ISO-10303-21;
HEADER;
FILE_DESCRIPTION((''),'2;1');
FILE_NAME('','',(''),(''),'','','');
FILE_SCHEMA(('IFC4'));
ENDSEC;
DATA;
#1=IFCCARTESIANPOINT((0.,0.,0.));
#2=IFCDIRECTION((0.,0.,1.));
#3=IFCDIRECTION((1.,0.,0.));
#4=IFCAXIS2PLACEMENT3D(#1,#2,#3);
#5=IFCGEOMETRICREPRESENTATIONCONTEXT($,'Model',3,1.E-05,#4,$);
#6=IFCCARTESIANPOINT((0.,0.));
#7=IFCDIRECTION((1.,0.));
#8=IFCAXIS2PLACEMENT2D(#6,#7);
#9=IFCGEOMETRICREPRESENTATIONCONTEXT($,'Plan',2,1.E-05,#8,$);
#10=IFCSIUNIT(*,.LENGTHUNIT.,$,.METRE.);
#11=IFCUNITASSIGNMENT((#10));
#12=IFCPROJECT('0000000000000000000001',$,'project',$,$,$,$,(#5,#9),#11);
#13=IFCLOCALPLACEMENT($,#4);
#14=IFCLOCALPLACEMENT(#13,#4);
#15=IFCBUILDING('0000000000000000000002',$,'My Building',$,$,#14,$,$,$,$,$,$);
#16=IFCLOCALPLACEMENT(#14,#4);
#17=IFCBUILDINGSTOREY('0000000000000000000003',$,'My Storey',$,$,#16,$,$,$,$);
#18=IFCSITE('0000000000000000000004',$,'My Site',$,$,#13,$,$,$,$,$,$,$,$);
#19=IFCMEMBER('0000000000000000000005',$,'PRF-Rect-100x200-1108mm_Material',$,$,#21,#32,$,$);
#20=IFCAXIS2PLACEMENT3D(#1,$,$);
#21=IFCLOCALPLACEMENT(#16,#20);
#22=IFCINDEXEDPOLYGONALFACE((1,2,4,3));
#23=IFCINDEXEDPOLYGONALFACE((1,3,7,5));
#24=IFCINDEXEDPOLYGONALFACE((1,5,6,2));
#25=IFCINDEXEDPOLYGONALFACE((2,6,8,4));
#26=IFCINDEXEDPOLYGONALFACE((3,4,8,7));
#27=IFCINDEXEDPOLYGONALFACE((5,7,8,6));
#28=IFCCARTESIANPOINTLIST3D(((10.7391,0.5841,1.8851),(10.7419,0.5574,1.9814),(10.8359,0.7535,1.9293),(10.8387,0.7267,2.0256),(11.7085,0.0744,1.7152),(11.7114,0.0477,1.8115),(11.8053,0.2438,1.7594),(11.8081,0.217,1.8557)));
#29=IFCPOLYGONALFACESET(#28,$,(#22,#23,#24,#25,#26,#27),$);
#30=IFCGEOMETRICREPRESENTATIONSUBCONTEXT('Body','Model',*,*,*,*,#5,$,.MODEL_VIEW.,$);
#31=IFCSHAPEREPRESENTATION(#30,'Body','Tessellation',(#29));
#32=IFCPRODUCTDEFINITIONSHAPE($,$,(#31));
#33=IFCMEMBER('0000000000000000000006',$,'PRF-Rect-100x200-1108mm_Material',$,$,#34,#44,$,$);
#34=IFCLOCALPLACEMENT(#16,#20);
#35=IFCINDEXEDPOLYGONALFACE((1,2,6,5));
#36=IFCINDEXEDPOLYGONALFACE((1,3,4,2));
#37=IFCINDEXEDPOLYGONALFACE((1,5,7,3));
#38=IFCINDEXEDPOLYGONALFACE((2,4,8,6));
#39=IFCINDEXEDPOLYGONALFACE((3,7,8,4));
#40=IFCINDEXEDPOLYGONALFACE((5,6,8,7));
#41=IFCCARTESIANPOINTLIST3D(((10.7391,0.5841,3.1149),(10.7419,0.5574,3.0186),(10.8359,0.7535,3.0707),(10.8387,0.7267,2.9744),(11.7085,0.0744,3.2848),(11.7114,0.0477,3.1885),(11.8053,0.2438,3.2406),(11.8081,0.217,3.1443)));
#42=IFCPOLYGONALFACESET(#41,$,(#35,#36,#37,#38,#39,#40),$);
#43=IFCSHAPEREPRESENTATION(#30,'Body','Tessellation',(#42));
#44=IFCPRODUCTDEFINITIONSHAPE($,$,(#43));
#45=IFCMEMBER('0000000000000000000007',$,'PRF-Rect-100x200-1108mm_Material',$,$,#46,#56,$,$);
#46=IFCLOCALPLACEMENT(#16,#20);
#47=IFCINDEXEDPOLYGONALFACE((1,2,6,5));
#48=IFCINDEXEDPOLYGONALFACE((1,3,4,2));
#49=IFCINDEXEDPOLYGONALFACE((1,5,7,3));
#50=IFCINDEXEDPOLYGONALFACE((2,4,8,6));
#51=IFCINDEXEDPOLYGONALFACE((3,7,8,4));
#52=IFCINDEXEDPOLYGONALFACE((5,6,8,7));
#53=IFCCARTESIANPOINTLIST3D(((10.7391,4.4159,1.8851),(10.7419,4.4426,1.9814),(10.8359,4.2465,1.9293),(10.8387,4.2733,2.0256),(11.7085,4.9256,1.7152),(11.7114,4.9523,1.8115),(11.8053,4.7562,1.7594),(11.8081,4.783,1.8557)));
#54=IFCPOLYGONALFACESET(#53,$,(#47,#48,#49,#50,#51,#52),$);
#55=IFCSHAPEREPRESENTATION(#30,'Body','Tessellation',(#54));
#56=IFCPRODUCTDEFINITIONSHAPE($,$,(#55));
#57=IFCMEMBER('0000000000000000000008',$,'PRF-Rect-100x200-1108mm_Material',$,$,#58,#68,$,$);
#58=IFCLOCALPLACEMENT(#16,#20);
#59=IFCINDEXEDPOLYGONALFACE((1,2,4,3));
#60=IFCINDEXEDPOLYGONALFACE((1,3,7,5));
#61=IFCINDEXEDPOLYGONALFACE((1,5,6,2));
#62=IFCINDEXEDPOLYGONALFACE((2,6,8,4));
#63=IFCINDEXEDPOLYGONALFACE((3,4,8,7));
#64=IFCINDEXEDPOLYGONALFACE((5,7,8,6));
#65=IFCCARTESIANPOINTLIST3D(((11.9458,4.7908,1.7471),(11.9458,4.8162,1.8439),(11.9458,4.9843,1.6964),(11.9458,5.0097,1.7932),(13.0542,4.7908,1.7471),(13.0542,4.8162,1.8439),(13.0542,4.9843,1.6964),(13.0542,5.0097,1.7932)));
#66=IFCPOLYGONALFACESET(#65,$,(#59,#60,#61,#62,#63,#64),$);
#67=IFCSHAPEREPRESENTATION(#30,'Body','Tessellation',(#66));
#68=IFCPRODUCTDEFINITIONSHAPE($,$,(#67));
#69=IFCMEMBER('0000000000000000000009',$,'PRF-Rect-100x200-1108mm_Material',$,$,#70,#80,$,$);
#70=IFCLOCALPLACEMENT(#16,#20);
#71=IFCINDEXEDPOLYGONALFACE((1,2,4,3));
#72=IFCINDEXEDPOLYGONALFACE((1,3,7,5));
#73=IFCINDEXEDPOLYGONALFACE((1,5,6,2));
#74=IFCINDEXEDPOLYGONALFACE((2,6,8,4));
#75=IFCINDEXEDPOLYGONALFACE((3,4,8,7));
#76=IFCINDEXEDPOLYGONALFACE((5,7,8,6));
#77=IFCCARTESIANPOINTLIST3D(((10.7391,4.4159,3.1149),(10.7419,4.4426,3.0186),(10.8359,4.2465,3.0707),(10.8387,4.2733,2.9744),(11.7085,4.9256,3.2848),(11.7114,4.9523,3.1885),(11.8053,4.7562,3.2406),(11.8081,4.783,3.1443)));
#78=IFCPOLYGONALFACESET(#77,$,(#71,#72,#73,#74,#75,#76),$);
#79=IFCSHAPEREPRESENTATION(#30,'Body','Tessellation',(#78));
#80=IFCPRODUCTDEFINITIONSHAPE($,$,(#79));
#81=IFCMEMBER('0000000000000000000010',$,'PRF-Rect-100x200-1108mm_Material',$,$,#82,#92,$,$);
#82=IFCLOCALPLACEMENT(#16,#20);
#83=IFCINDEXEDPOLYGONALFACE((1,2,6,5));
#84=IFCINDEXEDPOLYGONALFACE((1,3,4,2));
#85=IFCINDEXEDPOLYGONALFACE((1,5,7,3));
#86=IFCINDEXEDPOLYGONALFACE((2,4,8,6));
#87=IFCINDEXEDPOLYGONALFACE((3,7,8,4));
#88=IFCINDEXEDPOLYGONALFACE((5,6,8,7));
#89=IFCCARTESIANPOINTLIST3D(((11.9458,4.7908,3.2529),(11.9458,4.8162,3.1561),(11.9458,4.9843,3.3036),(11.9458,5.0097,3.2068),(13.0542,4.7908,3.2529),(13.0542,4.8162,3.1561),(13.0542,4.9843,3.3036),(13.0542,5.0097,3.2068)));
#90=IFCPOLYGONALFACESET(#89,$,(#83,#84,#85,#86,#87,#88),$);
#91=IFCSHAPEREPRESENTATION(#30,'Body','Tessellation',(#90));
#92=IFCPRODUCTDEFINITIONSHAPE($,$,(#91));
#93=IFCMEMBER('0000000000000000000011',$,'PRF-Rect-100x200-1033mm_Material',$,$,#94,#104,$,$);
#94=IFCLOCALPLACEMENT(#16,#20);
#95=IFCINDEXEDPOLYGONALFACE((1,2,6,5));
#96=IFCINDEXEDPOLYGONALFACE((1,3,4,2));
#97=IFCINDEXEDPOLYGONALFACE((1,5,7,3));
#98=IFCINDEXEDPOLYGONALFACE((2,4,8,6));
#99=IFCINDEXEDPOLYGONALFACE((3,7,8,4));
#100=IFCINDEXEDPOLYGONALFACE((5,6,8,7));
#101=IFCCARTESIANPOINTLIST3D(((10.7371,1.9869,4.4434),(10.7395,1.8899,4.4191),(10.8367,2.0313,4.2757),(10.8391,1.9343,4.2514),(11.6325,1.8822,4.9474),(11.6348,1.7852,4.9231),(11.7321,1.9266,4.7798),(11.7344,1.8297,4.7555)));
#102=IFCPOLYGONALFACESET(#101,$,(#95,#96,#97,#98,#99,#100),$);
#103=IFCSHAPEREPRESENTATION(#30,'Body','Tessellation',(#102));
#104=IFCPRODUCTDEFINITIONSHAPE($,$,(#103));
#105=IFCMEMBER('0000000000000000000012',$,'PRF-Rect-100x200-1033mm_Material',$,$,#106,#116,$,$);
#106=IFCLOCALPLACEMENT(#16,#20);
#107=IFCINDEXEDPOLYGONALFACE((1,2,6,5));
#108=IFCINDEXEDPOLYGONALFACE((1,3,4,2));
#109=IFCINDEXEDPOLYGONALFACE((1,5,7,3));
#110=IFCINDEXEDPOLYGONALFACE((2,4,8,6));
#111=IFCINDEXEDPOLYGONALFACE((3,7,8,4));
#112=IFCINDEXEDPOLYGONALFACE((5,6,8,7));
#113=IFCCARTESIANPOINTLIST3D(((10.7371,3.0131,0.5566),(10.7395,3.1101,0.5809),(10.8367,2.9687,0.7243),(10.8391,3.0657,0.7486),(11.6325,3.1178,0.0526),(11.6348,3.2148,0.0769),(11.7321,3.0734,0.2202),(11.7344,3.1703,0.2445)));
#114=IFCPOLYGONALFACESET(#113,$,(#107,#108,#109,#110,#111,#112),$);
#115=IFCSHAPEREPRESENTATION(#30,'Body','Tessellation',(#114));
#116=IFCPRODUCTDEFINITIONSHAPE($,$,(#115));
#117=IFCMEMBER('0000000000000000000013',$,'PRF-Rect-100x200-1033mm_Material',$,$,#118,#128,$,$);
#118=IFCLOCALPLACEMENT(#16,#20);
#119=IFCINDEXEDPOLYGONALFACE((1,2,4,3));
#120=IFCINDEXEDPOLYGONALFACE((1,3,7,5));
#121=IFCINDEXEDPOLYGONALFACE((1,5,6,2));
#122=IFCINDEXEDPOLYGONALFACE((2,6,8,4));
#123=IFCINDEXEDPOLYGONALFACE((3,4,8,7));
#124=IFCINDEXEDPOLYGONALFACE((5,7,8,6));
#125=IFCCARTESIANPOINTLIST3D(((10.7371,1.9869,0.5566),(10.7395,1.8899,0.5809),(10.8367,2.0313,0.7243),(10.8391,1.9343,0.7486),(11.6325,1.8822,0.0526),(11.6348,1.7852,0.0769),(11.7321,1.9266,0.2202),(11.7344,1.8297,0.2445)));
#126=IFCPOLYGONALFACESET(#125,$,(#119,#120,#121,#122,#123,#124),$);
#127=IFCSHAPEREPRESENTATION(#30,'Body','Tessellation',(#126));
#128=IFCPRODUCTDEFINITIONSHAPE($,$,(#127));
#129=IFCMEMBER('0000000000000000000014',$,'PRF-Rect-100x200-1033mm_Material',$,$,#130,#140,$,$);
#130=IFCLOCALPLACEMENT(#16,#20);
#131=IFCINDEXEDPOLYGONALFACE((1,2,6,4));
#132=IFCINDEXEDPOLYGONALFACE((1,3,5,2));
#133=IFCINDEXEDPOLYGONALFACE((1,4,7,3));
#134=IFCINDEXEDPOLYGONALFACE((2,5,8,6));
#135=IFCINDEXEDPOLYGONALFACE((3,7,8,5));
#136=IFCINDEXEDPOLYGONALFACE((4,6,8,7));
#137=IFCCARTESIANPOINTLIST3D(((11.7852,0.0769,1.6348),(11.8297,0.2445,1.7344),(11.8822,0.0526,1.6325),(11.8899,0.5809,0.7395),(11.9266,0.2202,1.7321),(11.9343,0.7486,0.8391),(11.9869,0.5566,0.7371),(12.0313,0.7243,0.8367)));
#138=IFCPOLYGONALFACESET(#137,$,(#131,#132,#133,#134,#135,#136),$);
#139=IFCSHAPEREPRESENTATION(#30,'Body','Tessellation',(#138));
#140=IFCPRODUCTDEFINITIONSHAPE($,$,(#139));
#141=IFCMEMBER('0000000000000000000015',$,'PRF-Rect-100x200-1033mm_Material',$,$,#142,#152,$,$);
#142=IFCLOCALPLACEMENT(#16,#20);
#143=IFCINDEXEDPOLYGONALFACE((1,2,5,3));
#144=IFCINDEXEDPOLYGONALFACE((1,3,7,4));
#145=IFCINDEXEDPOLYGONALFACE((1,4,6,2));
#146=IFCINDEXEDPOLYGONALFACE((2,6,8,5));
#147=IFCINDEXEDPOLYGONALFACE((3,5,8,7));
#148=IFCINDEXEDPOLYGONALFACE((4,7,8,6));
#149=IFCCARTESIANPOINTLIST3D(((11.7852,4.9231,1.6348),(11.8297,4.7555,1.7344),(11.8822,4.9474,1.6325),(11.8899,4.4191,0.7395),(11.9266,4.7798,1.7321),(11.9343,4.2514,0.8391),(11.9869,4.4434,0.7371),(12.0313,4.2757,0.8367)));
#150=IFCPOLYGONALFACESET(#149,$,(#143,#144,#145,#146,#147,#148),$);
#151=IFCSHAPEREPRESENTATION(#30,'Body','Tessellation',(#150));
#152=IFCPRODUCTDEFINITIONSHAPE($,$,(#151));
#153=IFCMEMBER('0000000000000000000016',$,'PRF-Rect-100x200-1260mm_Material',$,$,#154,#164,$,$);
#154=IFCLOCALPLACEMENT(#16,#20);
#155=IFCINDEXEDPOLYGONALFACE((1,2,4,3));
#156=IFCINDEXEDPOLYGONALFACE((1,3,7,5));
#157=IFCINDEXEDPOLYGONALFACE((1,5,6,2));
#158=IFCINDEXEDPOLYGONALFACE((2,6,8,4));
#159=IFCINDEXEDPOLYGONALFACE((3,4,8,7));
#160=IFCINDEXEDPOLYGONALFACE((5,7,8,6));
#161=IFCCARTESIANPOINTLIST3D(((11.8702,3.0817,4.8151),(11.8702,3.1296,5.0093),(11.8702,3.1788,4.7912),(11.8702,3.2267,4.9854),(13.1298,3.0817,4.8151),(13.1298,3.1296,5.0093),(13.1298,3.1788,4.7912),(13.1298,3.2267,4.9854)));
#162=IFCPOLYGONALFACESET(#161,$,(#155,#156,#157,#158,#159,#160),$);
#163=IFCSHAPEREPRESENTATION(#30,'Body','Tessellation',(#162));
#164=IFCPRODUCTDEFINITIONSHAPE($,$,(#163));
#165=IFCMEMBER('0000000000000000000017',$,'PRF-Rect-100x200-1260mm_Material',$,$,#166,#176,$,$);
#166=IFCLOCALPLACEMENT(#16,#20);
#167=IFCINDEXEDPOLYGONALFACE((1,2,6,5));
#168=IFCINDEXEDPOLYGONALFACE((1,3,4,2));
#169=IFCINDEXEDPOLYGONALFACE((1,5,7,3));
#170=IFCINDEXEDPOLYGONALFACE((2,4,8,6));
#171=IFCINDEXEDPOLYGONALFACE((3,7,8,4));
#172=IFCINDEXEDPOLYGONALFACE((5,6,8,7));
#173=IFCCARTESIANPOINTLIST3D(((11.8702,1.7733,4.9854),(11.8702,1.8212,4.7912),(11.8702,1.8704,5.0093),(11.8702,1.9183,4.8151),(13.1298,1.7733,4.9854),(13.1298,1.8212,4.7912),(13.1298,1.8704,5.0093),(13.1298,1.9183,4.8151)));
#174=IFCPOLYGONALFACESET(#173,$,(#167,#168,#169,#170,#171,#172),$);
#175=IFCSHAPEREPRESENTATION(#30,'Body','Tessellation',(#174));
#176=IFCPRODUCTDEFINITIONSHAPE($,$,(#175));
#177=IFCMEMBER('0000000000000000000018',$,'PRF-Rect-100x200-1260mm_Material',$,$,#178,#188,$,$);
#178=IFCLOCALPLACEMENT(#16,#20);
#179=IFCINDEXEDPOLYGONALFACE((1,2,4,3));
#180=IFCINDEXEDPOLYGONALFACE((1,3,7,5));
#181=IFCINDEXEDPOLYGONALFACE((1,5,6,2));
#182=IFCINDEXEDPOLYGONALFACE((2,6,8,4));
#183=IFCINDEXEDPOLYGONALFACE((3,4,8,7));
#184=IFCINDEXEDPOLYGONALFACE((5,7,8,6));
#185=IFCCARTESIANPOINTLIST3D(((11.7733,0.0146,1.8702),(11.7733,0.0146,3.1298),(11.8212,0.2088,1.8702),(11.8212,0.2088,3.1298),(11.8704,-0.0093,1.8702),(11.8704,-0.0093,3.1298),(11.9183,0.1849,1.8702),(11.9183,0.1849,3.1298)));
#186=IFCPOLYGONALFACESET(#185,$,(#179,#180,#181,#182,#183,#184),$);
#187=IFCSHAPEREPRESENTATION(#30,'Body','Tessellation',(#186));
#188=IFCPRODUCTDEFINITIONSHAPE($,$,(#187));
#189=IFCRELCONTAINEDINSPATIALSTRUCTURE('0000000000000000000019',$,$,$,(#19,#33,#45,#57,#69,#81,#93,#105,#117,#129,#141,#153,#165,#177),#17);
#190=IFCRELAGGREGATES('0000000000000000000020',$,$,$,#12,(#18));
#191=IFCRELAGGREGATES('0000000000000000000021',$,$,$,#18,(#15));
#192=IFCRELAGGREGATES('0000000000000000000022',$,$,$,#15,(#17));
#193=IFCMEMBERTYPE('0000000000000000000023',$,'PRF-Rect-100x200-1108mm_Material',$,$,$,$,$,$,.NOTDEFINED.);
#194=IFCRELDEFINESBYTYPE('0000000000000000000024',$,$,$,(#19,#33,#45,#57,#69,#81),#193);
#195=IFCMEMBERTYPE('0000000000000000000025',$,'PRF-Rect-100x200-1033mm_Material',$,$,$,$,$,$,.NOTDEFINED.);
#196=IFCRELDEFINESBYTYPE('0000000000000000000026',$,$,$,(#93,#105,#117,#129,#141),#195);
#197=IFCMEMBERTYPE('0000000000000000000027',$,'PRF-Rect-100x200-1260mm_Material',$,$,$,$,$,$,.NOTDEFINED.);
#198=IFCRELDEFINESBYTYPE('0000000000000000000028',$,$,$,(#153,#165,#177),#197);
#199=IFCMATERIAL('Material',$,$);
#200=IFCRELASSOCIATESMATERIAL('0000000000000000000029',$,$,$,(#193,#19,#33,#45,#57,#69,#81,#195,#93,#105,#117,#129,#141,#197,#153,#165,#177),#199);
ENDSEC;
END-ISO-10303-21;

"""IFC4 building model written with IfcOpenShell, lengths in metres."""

from ifc_helpers import new_model, si_unit, frame, origin, origin_with_axes, origin_2d_with_axis, place, context, subcontext, project, spatial, rectangle, extrude, material, material_profile, profile_set, profile_usage, type_object, element, save


model = new_model("IFC4")

# Units and contexts
model_context = context("Model", 3, precision=1e-05, world=origin_with_axes())
plan_context = context("Plan", 2, precision=1e-05, world=origin_2d_with_axis())
body_context = subcontext(model_context, "Body", "Model", "MODEL_VIEW")
ifc_project = project(units=[si_unit("LENGTHUNIT", "METRE")], contexts=[model_context, plan_context])

# Site, building, storey
site_placement = place(None, origin_with_axes())
site = spatial("IfcSite", under=ifc_project, at=site_placement, Name="My Site")
building_placement = place(site_placement, origin_with_axes())
building = spatial("IfcBuilding", under=site, at=building_placement, Name="My Building")
storey_placement = place(building_placement, origin_with_axes())
storey = spatial("IfcBuildingStorey", under=building, at=storey_placement, Name="My Storey")

# Members
ifc_material = material(Name="Material")
ifc_material_profile_1 = material_profile(ifc_material, rectangle(XDim=0.1, YDim=0.2))
ifc_profile_set_1 = profile_set([ifc_material_profile_1], Name="PRF-Rect-100x200-1108mm_Material")
member_type_1 = type_object("IfcMemberType", Name="PRF-Rect-100x200-1108mm_Material", PredefinedType="NOTDEFINED", material=ifc_profile_set_1)
ifc_profile_usage_1 = profile_usage(ifc_profile_set_1, cardinal=5)
member_1_placement = place(storey_placement, frame((11.7583, 0.1457, 1.7855), z_axis=(-0.874667, 0.459849, 0.153283), x_axis=(-0.028153, 0.2675, -0.963147)))
element("IfcMember", 1, at=member_1_placement, inside=storey, type_object=member_type_1, material=ifc_profile_usage_1, Name="PRF-Rect-100x200-1108mm_Material", context=body_context, shape_type="SweptSolid", body=[
    extrude(rectangle(XDim=0.1, YDim=0.2), origin(), (0.0, 0.0, 1.0), 1.1084),
])
ifc_profile_usage_2 = profile_usage(ifc_profile_set_1, cardinal=5)
member_2_placement = place(storey_placement, frame((11.7583, 0.1457, 3.2145), z_axis=(-0.874668, 0.459849, -0.153283), x_axis=(0.028153, -0.2675, -0.963147)))
element("IfcMember", 2, at=member_2_placement, inside=storey, type_object=member_type_1, material=ifc_profile_usage_2, Name="PRF-Rect-100x200-1108mm_Material", context=body_context, shape_type="SweptSolid", body=[
    extrude(rectangle(XDim=0.1, YDim=0.2), origin(), (0.0, 0.0, 1.0), 1.1084),
])
ifc_profile_usage_3 = profile_usage(ifc_profile_set_1, cardinal=5)
member_3_placement = place(storey_placement, frame((10.7889, 4.3446, 1.9554), z_axis=(0.874668, 0.459849, -0.153283), x_axis=(-0.028153, -0.2675, -0.963147)))
element("IfcMember", 3, at=member_3_placement, inside=storey, type_object=member_type_1, material=ifc_profile_usage_3, Name="PRF-Rect-100x200-1108mm_Material", context=body_context, shape_type="SweptSolid", body=[
    extrude(rectangle(XDim=0.1, YDim=0.2), origin(), (0.0, 0.0, 1.0), 1.1084),
])
ifc_profile_usage_4 = profile_usage(ifc_profile_set_1, cardinal=5)
member_4_placement = place(storey_placement, frame((11.9458, 4.9002, 1.7702), z_axis=(1.0, 0.0, 0.0), x_axis=(0.0, -0.253569, -0.967317)))
element("IfcMember", 4, at=member_4_placement, inside=storey, type_object=member_type_1, material=ifc_profile_usage_4, Name="PRF-Rect-100x200-1108mm_Material", context=body_context, shape_type="SweptSolid", body=[
    extrude(rectangle(XDim=0.1, YDim=0.2), origin(), (0.0, 0.0, 1.0), 1.1084),
])
ifc_profile_usage_5 = profile_usage(ifc_profile_set_1, cardinal=5)
member_5_placement = place(storey_placement, frame((10.7889, 4.3446, 3.0446), z_axis=(0.874667, 0.459849, 0.153283), x_axis=(0.028153, 0.2675, -0.963147)))
element("IfcMember", 5, at=member_5_placement, inside=storey, type_object=member_type_1, material=ifc_profile_usage_5, Name="PRF-Rect-100x200-1108mm_Material", context=body_context, shape_type="SweptSolid", body=[
    extrude(rectangle(XDim=0.1, YDim=0.2), origin(), (0.0, 0.0, 1.0), 1.1084),
])
ifc_profile_usage_6 = profile_usage(ifc_profile_set_1, cardinal=5)
member_6_placement = place(storey_placement, frame((11.9458, 4.9002, 3.2298), z_axis=(1.0, 0.0, 0.0), x_axis=(0.0, 0.253569, -0.967317)))
element("IfcMember", 6, at=member_6_placement, inside=storey, type_object=member_type_1, material=ifc_profile_usage_6, Name="PRF-Rect-100x200-1108mm_Material", context=body_context, shape_type="SweptSolid", body=[
    extrude(rectangle(XDim=0.1, YDim=0.2), origin(), (0.0, 0.0, 1.0), 1.1084),
])
ifc_material_profile_2 = material_profile(ifc_material, rectangle(XDim=0.1, YDim=0.2))
ifc_profile_set_2 = profile_set([ifc_material_profile_2], Name="PRF-Rect-100x200-1033mm_Material")
ifc_profile_usage_7 = profile_usage(ifc_profile_set_2, cardinal=5)
member_type_2 = type_object("IfcMemberType", Name="PRF-Rect-100x200-1033mm_Material", PredefinedType="NOTDEFINED", material=ifc_profile_set_2)
member_7_placement = place(storey_placement, frame((10.7881, 1.9606, 4.3474), z_axis=(0.866922, -0.101315, 0.488039), x_axis=(-0.023454, 0.969748, 0.242978)))
element("IfcMember", 7, at=member_7_placement, inside=storey, type_object=member_type_2, material=ifc_profile_usage_7, Name="PRF-Rect-100x200-1033mm_Material", context=body_context, shape_type="SweptSolid", body=[
    extrude(rectangle(XDim=0.1, YDim=0.2), origin(), (0.0, 0.0, 1.0), 1.0328),
])
ifc_profile_usage_8 = profile_usage(ifc_profile_set_2, cardinal=5)
member_8_placement = place(storey_placement, frame((11.6835, 3.1441, 0.1486), z_axis=(-0.866922, -0.101314, 0.488039), x_axis=(0.023454, 0.969748, 0.242978)))
element("IfcMember", 8, at=member_8_placement, inside=storey, type_object=member_type_2, material=ifc_profile_usage_8, Name="PRF-Rect-100x200-1033mm_Material", context=body_context, shape_type="SweptSolid", body=[
    extrude(rectangle(XDim=0.1, YDim=0.2), origin(), (0.0, 0.0, 1.0), 1.0328),
])
ifc_profile_usage_9 = profile_usage(ifc_profile_set_2, cardinal=5)
member_9_placement = place(storey_placement, frame((11.6835, 1.8559, 0.1486), z_axis=(-0.866922, 0.101314, 0.488039), x_axis=(-0.023455, 0.969748, -0.242978)))
element("IfcMember", 9, at=member_9_placement, inside=storey, type_object=member_type_2, material=ifc_profile_usage_9, Name="PRF-Rect-100x200-1033mm_Material", context=body_context, shape_type="SweptSolid", body=[
    extrude(rectangle(XDim=0.1, YDim=0.2), origin(), (0.0, 0.0, 1.0), 1.0328),
])
ifc_profile_usage_10 = profile_usage(ifc_profile_set_2, cardinal=5)
member_10_placement = place(storey_placement, frame((11.8559, 0.1486, 1.6835), z_axis=(0.101315, 0.488039, -0.866922), x_axis=(0.969748, -0.242978, -0.023454)))
element("IfcMember", 10, at=member_10_placement, inside=storey, type_object=member_type_2, material=ifc_profile_usage_10, Name="PRF-Rect-100x200-1033mm_Material", context=body_context, shape_type="SweptSolid", body=[
    extrude(rectangle(XDim=0.1, YDim=0.2), origin(), (0.0, 0.0, 1.0), 1.0328),
])
ifc_profile_usage_11 = profile_usage(ifc_profile_set_2, cardinal=5)
member_11_placement = place(storey_placement, frame((11.8559, 4.8514, 1.6835), z_axis=(0.101315, -0.488039, -0.866922), x_axis=(-0.969748, -0.242978, 0.023454)))
element("IfcMember", 11, at=member_11_placement, inside=storey, type_object=member_type_2, material=ifc_profile_usage_11, Name="PRF-Rect-100x200-1033mm_Material", context=body_context, shape_type="SweptSolid", body=[
    extrude(rectangle(XDim=0.1, YDim=0.2), origin(), (0.0, 0.0, 1.0), 1.0328),
])
ifc_material_profile_3 = material_profile(ifc_material, rectangle(XDim=0.1, YDim=0.2))
ifc_profile_set_3 = profile_set([ifc_material_profile_3], Name="PRF-Rect-100x200-1260mm_Material")
ifc_profile_usage_12 = profile_usage(ifc_profile_set_3, cardinal=5)
member_type_3 = type_object("IfcMemberType", Name="PRF-Rect-100x200-1260mm_Material", PredefinedType="NOTDEFINED", material=ifc_profile_set_3)
member_12_placement = place(storey_placement, frame((11.8702, 3.1542, 4.9002), z_axis=(1.0, 0.0, 0.0), x_axis=(0.0, 0.970857, -0.239658)))
element("IfcMember", 12, at=member_12_placement, inside=storey, type_object=member_type_3, material=ifc_profile_usage_12, Name="PRF-Rect-100x200-1260mm_Material", context=body_context, shape_type="SweptSolid", body=[
    extrude(rectangle(XDim=0.1, YDim=0.2), origin(), (0.0, 0.0, 1.0), 1.2597),
])
ifc_profile_usage_13 = profile_usage(ifc_profile_set_3, cardinal=5)
member_13_placement = place(storey_placement, frame((11.8702, 1.8458, 4.9002), z_axis=(1.0, 0.0, 0.0), x_axis=(0.0, 0.970857, 0.239659)))
element("IfcMember", 13, at=member_13_placement, inside=storey, type_object=member_type_3, material=ifc_profile_usage_13, Name="PRF-Rect-100x200-1260mm_Material", context=body_context, shape_type="SweptSolid", body=[
    extrude(rectangle(XDim=0.1, YDim=0.2), origin(), (0.0, 0.0, 1.0), 1.2597),
])
ifc_profile_usage_14 = profile_usage(ifc_profile_set_3, cardinal=5)
member_14_placement = place(storey_placement, frame((11.8458, 0.0998, 3.1298), z_axis=(0.0, 0.0, -1.0), x_axis=(0.970857, -0.239658, 0.0)))
element("IfcMember", 14, at=member_14_placement, inside=storey, type_object=member_type_3, material=ifc_profile_usage_14, Name="PRF-Rect-100x200-1260mm_Material", context=body_context, shape_type="SweptSolid", body=[
    extrude(rectangle(XDim=0.1, YDim=0.2), origin(), (0.0, 0.0, 1.0), 1.2597),
])

save(model, "model.ifc")
